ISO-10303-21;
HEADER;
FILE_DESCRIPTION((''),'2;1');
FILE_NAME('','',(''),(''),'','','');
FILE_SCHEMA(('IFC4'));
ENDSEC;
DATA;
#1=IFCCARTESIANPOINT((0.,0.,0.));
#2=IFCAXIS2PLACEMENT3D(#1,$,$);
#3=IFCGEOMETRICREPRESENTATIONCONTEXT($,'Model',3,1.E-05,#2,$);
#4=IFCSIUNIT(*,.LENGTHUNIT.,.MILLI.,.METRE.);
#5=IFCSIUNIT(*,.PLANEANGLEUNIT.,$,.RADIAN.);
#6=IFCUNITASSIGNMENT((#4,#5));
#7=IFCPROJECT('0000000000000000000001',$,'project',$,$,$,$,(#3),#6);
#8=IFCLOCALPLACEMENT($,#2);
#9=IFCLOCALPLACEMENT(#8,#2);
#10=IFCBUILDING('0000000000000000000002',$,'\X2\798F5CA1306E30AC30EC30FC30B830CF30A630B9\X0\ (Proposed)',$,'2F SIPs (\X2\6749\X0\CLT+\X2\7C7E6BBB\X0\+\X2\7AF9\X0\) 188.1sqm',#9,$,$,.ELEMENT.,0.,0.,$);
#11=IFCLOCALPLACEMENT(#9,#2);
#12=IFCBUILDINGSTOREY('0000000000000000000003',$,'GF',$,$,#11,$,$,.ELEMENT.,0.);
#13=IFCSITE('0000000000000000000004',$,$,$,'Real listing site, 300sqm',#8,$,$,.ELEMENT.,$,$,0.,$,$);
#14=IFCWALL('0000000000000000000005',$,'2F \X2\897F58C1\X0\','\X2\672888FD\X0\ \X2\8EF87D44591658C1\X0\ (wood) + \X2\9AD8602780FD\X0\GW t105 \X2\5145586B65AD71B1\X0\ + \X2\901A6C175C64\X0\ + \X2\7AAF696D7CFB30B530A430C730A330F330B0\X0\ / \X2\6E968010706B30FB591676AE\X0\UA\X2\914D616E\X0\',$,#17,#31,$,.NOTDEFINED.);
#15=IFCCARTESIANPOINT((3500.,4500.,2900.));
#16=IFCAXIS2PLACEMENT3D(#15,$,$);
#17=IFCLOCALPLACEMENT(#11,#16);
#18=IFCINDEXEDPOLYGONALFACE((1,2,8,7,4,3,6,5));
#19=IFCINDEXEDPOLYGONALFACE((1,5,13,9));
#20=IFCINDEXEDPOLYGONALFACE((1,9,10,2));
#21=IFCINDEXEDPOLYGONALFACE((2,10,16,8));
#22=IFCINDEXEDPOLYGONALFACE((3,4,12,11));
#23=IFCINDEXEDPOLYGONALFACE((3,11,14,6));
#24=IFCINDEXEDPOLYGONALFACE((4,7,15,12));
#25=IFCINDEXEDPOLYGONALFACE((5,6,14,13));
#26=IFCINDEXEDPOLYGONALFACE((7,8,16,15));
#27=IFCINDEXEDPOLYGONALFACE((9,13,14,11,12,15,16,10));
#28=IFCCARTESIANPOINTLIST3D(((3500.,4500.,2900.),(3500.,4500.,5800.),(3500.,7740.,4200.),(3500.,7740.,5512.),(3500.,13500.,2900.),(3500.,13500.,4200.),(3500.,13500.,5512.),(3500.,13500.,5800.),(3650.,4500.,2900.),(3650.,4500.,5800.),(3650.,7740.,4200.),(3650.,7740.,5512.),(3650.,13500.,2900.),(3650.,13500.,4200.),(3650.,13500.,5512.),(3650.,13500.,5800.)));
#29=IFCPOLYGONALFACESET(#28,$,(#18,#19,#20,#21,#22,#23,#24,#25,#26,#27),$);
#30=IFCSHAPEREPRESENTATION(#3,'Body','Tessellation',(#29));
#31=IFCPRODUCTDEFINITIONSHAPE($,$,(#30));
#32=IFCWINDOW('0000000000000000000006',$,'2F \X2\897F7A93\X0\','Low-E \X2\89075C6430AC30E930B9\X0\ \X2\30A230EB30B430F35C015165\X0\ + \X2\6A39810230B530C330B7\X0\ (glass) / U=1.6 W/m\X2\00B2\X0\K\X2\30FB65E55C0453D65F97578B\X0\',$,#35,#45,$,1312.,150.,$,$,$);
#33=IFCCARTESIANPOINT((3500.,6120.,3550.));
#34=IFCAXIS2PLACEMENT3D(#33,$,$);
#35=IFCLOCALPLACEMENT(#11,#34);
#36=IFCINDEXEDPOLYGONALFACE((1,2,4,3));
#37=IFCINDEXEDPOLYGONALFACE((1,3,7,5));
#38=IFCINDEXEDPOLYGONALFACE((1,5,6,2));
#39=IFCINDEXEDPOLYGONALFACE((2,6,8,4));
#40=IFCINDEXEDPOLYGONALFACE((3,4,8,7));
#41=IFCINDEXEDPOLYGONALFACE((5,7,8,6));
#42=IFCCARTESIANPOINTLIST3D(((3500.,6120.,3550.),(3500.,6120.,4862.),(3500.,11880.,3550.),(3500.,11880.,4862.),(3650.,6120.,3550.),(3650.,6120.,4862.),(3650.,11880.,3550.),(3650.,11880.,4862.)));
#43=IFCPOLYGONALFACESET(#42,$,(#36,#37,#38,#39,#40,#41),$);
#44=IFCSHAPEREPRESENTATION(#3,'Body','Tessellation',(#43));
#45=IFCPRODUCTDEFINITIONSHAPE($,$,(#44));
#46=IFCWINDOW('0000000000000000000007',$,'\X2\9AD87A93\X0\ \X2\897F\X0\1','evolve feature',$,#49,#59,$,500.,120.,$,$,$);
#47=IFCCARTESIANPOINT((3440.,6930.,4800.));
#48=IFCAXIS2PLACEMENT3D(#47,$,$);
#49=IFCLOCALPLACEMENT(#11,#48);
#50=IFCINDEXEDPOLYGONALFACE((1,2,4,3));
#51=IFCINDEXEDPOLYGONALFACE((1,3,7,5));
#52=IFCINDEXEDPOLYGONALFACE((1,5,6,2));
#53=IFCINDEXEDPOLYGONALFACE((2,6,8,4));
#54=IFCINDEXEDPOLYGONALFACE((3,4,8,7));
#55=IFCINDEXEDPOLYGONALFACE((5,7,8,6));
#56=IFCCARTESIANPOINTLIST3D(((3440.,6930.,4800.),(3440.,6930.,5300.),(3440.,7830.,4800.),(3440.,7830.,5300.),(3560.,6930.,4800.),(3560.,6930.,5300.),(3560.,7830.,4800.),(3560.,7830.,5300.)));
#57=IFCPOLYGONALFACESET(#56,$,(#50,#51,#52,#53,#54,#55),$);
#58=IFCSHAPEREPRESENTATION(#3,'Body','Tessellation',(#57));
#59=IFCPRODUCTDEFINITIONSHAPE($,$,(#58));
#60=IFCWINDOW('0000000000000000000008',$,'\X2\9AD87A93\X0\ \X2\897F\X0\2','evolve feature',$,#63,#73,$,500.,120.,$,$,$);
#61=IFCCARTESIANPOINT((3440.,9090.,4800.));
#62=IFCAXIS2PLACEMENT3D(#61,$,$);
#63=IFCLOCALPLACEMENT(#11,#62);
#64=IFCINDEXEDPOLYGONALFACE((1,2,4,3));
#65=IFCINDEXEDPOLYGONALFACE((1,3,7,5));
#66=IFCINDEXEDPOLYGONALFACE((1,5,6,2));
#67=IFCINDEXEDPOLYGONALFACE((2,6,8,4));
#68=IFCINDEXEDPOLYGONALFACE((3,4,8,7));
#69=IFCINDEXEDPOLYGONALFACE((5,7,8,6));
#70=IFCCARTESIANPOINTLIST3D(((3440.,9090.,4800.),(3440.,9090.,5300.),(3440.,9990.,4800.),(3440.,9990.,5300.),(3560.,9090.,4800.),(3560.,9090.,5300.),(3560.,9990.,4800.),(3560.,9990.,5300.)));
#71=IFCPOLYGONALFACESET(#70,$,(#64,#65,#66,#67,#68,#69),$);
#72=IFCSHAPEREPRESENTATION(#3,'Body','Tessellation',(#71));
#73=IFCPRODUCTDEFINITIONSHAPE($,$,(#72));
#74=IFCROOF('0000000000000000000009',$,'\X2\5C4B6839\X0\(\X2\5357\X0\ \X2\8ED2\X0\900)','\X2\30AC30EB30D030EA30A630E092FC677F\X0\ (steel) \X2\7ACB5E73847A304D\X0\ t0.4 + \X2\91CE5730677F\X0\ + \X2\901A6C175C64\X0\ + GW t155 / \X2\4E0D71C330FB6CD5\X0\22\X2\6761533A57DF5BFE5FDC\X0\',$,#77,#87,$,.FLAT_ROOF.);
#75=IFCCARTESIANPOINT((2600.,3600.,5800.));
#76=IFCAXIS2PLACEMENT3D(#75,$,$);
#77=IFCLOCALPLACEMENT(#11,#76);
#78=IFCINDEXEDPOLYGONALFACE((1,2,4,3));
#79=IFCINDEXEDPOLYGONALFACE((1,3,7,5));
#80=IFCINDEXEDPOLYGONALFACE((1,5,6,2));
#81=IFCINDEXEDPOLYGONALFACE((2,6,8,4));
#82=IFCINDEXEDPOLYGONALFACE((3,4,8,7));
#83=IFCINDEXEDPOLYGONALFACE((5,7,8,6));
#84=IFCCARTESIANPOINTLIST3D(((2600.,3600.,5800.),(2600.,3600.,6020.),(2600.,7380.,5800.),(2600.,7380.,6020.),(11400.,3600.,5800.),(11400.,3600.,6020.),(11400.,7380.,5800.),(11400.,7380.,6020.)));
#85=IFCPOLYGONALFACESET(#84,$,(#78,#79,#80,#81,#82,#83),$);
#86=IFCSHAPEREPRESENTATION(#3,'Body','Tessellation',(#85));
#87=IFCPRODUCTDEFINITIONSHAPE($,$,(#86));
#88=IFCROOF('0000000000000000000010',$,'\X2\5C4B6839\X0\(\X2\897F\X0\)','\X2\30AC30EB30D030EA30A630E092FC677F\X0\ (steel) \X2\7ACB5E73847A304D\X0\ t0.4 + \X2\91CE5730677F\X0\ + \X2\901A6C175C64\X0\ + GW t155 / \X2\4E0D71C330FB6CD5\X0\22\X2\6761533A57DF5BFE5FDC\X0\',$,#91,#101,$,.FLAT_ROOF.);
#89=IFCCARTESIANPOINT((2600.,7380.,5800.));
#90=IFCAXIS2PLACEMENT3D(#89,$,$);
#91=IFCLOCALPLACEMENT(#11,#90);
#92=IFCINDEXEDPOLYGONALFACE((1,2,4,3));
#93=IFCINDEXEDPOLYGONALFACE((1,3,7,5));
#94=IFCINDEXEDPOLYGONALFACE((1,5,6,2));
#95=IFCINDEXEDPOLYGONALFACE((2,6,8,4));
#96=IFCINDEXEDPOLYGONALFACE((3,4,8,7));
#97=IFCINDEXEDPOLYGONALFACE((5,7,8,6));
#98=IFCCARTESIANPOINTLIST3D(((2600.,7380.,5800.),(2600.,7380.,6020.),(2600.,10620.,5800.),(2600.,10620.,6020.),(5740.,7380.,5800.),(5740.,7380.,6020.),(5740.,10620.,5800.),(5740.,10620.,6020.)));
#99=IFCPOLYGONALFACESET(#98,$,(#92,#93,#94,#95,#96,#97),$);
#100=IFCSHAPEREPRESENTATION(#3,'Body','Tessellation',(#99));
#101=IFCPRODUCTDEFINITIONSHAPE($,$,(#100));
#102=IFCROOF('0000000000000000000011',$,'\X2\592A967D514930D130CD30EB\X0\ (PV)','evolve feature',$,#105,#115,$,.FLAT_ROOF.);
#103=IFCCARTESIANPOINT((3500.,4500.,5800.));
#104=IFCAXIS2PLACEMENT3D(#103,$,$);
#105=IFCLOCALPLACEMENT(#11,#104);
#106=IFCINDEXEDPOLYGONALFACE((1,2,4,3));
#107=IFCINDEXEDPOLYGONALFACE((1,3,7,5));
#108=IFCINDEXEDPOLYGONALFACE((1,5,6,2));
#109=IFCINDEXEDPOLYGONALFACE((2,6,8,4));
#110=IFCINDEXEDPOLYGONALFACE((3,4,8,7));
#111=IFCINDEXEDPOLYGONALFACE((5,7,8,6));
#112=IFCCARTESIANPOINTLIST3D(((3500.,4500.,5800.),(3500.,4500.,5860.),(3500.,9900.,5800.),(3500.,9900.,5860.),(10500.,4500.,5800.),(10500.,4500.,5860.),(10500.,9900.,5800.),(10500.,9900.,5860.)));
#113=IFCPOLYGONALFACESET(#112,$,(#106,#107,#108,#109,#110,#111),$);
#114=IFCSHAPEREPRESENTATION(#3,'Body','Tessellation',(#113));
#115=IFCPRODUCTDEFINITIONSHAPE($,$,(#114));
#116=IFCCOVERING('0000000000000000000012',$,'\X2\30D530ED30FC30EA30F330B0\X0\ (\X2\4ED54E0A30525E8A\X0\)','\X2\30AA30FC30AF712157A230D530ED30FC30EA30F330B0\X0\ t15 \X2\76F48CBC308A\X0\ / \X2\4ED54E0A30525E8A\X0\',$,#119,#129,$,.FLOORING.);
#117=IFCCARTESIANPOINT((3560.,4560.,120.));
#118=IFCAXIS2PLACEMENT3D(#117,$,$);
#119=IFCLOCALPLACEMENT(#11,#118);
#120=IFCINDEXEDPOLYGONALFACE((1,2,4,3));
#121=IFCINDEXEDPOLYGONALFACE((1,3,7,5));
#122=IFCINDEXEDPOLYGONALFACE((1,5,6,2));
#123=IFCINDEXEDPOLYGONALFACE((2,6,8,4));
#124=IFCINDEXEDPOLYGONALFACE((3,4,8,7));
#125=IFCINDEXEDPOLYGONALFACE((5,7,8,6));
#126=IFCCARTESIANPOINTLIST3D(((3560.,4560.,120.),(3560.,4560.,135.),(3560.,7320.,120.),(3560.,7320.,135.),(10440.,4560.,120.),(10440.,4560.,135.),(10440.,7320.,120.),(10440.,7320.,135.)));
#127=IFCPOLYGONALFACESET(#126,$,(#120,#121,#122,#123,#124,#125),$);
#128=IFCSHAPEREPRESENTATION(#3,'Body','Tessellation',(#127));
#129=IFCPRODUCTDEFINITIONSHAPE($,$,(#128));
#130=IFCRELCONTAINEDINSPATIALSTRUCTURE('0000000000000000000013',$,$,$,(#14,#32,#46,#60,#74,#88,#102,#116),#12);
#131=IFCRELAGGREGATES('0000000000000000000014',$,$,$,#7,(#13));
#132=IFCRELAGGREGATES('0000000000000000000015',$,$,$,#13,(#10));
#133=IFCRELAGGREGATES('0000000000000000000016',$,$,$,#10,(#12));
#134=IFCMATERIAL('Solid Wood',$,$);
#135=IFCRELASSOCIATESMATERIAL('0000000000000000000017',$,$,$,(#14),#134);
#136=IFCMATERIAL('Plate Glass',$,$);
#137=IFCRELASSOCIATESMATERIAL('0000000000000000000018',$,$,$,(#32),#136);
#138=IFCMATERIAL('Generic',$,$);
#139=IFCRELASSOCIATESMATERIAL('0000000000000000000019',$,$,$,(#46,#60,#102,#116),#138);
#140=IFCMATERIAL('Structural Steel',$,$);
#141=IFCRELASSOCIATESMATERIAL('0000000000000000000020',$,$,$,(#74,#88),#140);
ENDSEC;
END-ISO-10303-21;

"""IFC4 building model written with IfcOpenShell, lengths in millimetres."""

from ifc_helpers import new_model, si_unit, frame, frame_2d, origin, place, context, project, spatial, rectangle, extrude, material, element, fill, save


model = new_model("IFC4")

# Units and contexts
model_context = context("Model", 3, precision=1e-05, world=origin())
ifc_project = project(units=[si_unit("LENGTHUNIT", "METRE", prefix="MILLI"), si_unit("PLANEANGLEUNIT", "RADIAN")], contexts=[model_context])

# Site, building, storey
site_placement = place(None, origin())
site = spatial("IfcSite", under=ifc_project, at=site_placement, ObjectType="Real listing site, 300sqm", CompositionType="ELEMENT", RefElevation=0.0)
building_placement = place(site_placement, origin())
building = spatial("IfcBuilding", under=site, at=building_placement, Name="福岡のガレージハウス (Proposed)", ObjectType="2F SIPs (杉CLT+籾殻+竹) 188.1sqm", CompositionType="ELEMENT", ElevationOfRefHeight=0.0, ElevationOfTerrain=0.0)
storey_placement = place(building_placement, origin())
storey = spatial("IfcBuildingStorey", under=building, at=storey_placement, Name="GF", CompositionType="ELEMENT", Elevation=0.0)

# Shared definitions
ifc_material_1 = material(Name="Solid Wood")
ifc_material_2 = material(Name="Generic")

# Shared definitions
ifc_material_3 = material(Name="Plate Glass")

# Wall, openings, windows
wall_1_placement = place(storey_placement, frame((3500.0, 4500.0, 2900.0)))
wall_1 = element("IfcWall", 1, at=wall_1_placement, inside=storey, material=ifc_material_1, Name="2F 西壁", Description="木製 軸組外壁 (wood) + 高性能GW t105 充填断熱 + 通気層 + 窯業系サイディング / 準耐火・外皮UA配慮", PredefinedType="NOTDEFINED", context=model_context, shape_type="SweptSolid", body=[
    extrude(rectangle(XDim=150.0, YDim=9000.0, at=frame_2d((75.0, 4500.0))), frame((3500.0, 4500.0, 2900.0)), (0.0, 0.0, 1.0), 2900.0),
])
opening_1_placement = place(storey_placement, frame((3500.0, 6120.0, 3550.0)))
opening_1 = element("IfcOpeningElement", 2, at=opening_1_placement, cuts=wall_1, PredefinedType="NOTDEFINED", context=model_context, shape_type="SweptSolid", body=[
    extrude(rectangle(XDim=150.0, YDim=5760.0, at=frame_2d((75.0, 2880.0))), frame((3500.0, 6120.0, 3550.0)), (0.0, 0.0, 1.0), 1312.0),
])
opening_2_placement = place(storey_placement, frame((3440.0, 6930.0, 4800.0)))
opening_2 = element("IfcOpeningElement", 3, at=opening_2_placement, cuts=wall_1, PredefinedType="NOTDEFINED", context=model_context, shape_type="SweptSolid", body=[
    extrude(rectangle(XDim=120.0, YDim=900.0, at=frame_2d((60.0, 450.0))), frame((3440.0, 6930.0, 4800.0)), (0.0, 0.0, 1.0), 500.0),
])
opening_3_placement = place(storey_placement, frame((3440.0, 9090.0, 4800.0)))
opening_3 = element("IfcOpeningElement", 4, at=opening_3_placement, cuts=wall_1, PredefinedType="NOTDEFINED", context=model_context, shape_type="SweptSolid", body=[
    extrude(rectangle(XDim=120.0, YDim=900.0, at=frame_2d((60.0, 450.0))), frame((3440.0, 9090.0, 4800.0)), (0.0, 0.0, 1.0), 500.0),
])
window_1_placement = place(storey_placement, frame((3500.0, 6120.0, 3550.0)))
window_1 = element("IfcWindow", 5, at=window_1_placement, inside=storey, material=ifc_material_3, Name="2F 西窓", Description="Low-E 複層ガラス アルゴン封入 + 樹脂サッシ (glass) / U=1.6 W/m²K・日射取得型", OverallHeight=1312.0, OverallWidth=150.0, context=model_context, shape_type="SweptSolid", body=[
    extrude(rectangle(XDim=150.0, YDim=5760.0, at=frame_2d((75.0, 2880.0))), frame((3500.0, 6120.0, 3550.0)), (0.0, 0.0, 1.0), 1312.0),
])
fill(opening_1, window_1)
window_2_placement = place(storey_placement, frame((3440.0, 6930.0, 4800.0)))
window_2 = element("IfcWindow", 6, at=window_2_placement, inside=storey, material=ifc_material_2, Name="高窓 西1", Description="evolve feature", OverallHeight=500.0, OverallWidth=120.0, context=model_context, shape_type="SweptSolid", body=[
    extrude(rectangle(XDim=120.0, YDim=900.0, at=frame_2d((60.0, 450.0))), frame((3440.0, 6930.0, 4800.0)), (0.0, 0.0, 1.0), 500.0),
])
fill(opening_2, window_2)
window_3_placement = place(storey_placement, frame((3440.0, 9090.0, 4800.0)))
window_3 = element("IfcWindow", 7, at=window_3_placement, inside=storey, material=ifc_material_2, Name="高窓 西2", Description="evolve feature", OverallHeight=500.0, OverallWidth=120.0, context=model_context, shape_type="SweptSolid", body=[
    extrude(rectangle(XDim=120.0, YDim=900.0, at=frame_2d((60.0, 450.0))), frame((3440.0, 9090.0, 4800.0)), (0.0, 0.0, 1.0), 500.0),
])
fill(opening_3, window_3)

# Roofs
ifc_material_4 = material(Name="Structural Steel")
roof_1_placement = place(storey_placement, frame((2600.0, 3600.0, 5800.0)))
element("IfcRoof", 8, at=roof_1_placement, inside=storey, material=ifc_material_4, Name="屋根(南 軒900)", Description="ガルバリウム鋼板 (steel) 立平葺き t0.4 + 野地板 + 通気層 + GW t155 / 不燃・法22条区域対応", PredefinedType="FLAT_ROOF", context=model_context, shape_type="SweptSolid", body=[
    extrude(rectangle(XDim=8800.0, YDim=3780.0, at=frame_2d((4400.0, 1890.0))), frame((2600.0, 3600.0, 5800.0)), (0.0, 0.0, 1.0), 220.0),
])
roof_2_placement = place(storey_placement, frame((2600.0, 7380.0, 5800.0)))
element("IfcRoof", 9, at=roof_2_placement, inside=storey, material=ifc_material_4, Name="屋根(西)", Description="ガルバリウム鋼板 (steel) 立平葺き t0.4 + 野地板 + 通気層 + GW t155 / 不燃・法22条区域対応", PredefinedType="FLAT_ROOF", context=model_context, shape_type="SweptSolid", body=[
    extrude(rectangle(XDim=3140.0, YDim=3240.0, at=frame_2d((1570.0, 1620.0))), frame((2600.0, 7380.0, 5800.0)), (0.0, 0.0, 1.0), 220.0),
])
roof_3_placement = place(storey_placement, frame((3500.0, 4500.0, 5800.0)))
element("IfcRoof", 10, at=roof_3_placement, inside=storey, material=ifc_material_2, Name="太陽光パネル (PV)", Description="evolve feature", PredefinedType="FLAT_ROOF", context=model_context, shape_type="SweptSolid", body=[
    extrude(rectangle(XDim=7000.0, YDim=5400.0, at=frame_2d((3500.0, 2700.0))), frame((3500.0, 4500.0, 5800.0)), (0.0, 0.0, 1.0), 60.0),
])

# Covering
covering_placement = place(storey_placement, frame((3560.0, 4560.0, 120.0)))
element("IfcCovering", 11, at=covering_placement, inside=storey, material=ifc_material_2, Name="フローリング (仕上げ床)", Description="オーク無垢フローリング t15 直貼り / 仕上げ床", PredefinedType="FLOORING", context=model_context, shape_type="SweptSolid", body=[
    extrude(rectangle(XDim=6880.0, YDim=2760.0, at=frame_2d((3440.0, 1380.0))), frame((3560.0, 4560.0, 120.0)), (0.0, 0.0, 1.0), 15.0),
])

save(model, "model.ifc")
